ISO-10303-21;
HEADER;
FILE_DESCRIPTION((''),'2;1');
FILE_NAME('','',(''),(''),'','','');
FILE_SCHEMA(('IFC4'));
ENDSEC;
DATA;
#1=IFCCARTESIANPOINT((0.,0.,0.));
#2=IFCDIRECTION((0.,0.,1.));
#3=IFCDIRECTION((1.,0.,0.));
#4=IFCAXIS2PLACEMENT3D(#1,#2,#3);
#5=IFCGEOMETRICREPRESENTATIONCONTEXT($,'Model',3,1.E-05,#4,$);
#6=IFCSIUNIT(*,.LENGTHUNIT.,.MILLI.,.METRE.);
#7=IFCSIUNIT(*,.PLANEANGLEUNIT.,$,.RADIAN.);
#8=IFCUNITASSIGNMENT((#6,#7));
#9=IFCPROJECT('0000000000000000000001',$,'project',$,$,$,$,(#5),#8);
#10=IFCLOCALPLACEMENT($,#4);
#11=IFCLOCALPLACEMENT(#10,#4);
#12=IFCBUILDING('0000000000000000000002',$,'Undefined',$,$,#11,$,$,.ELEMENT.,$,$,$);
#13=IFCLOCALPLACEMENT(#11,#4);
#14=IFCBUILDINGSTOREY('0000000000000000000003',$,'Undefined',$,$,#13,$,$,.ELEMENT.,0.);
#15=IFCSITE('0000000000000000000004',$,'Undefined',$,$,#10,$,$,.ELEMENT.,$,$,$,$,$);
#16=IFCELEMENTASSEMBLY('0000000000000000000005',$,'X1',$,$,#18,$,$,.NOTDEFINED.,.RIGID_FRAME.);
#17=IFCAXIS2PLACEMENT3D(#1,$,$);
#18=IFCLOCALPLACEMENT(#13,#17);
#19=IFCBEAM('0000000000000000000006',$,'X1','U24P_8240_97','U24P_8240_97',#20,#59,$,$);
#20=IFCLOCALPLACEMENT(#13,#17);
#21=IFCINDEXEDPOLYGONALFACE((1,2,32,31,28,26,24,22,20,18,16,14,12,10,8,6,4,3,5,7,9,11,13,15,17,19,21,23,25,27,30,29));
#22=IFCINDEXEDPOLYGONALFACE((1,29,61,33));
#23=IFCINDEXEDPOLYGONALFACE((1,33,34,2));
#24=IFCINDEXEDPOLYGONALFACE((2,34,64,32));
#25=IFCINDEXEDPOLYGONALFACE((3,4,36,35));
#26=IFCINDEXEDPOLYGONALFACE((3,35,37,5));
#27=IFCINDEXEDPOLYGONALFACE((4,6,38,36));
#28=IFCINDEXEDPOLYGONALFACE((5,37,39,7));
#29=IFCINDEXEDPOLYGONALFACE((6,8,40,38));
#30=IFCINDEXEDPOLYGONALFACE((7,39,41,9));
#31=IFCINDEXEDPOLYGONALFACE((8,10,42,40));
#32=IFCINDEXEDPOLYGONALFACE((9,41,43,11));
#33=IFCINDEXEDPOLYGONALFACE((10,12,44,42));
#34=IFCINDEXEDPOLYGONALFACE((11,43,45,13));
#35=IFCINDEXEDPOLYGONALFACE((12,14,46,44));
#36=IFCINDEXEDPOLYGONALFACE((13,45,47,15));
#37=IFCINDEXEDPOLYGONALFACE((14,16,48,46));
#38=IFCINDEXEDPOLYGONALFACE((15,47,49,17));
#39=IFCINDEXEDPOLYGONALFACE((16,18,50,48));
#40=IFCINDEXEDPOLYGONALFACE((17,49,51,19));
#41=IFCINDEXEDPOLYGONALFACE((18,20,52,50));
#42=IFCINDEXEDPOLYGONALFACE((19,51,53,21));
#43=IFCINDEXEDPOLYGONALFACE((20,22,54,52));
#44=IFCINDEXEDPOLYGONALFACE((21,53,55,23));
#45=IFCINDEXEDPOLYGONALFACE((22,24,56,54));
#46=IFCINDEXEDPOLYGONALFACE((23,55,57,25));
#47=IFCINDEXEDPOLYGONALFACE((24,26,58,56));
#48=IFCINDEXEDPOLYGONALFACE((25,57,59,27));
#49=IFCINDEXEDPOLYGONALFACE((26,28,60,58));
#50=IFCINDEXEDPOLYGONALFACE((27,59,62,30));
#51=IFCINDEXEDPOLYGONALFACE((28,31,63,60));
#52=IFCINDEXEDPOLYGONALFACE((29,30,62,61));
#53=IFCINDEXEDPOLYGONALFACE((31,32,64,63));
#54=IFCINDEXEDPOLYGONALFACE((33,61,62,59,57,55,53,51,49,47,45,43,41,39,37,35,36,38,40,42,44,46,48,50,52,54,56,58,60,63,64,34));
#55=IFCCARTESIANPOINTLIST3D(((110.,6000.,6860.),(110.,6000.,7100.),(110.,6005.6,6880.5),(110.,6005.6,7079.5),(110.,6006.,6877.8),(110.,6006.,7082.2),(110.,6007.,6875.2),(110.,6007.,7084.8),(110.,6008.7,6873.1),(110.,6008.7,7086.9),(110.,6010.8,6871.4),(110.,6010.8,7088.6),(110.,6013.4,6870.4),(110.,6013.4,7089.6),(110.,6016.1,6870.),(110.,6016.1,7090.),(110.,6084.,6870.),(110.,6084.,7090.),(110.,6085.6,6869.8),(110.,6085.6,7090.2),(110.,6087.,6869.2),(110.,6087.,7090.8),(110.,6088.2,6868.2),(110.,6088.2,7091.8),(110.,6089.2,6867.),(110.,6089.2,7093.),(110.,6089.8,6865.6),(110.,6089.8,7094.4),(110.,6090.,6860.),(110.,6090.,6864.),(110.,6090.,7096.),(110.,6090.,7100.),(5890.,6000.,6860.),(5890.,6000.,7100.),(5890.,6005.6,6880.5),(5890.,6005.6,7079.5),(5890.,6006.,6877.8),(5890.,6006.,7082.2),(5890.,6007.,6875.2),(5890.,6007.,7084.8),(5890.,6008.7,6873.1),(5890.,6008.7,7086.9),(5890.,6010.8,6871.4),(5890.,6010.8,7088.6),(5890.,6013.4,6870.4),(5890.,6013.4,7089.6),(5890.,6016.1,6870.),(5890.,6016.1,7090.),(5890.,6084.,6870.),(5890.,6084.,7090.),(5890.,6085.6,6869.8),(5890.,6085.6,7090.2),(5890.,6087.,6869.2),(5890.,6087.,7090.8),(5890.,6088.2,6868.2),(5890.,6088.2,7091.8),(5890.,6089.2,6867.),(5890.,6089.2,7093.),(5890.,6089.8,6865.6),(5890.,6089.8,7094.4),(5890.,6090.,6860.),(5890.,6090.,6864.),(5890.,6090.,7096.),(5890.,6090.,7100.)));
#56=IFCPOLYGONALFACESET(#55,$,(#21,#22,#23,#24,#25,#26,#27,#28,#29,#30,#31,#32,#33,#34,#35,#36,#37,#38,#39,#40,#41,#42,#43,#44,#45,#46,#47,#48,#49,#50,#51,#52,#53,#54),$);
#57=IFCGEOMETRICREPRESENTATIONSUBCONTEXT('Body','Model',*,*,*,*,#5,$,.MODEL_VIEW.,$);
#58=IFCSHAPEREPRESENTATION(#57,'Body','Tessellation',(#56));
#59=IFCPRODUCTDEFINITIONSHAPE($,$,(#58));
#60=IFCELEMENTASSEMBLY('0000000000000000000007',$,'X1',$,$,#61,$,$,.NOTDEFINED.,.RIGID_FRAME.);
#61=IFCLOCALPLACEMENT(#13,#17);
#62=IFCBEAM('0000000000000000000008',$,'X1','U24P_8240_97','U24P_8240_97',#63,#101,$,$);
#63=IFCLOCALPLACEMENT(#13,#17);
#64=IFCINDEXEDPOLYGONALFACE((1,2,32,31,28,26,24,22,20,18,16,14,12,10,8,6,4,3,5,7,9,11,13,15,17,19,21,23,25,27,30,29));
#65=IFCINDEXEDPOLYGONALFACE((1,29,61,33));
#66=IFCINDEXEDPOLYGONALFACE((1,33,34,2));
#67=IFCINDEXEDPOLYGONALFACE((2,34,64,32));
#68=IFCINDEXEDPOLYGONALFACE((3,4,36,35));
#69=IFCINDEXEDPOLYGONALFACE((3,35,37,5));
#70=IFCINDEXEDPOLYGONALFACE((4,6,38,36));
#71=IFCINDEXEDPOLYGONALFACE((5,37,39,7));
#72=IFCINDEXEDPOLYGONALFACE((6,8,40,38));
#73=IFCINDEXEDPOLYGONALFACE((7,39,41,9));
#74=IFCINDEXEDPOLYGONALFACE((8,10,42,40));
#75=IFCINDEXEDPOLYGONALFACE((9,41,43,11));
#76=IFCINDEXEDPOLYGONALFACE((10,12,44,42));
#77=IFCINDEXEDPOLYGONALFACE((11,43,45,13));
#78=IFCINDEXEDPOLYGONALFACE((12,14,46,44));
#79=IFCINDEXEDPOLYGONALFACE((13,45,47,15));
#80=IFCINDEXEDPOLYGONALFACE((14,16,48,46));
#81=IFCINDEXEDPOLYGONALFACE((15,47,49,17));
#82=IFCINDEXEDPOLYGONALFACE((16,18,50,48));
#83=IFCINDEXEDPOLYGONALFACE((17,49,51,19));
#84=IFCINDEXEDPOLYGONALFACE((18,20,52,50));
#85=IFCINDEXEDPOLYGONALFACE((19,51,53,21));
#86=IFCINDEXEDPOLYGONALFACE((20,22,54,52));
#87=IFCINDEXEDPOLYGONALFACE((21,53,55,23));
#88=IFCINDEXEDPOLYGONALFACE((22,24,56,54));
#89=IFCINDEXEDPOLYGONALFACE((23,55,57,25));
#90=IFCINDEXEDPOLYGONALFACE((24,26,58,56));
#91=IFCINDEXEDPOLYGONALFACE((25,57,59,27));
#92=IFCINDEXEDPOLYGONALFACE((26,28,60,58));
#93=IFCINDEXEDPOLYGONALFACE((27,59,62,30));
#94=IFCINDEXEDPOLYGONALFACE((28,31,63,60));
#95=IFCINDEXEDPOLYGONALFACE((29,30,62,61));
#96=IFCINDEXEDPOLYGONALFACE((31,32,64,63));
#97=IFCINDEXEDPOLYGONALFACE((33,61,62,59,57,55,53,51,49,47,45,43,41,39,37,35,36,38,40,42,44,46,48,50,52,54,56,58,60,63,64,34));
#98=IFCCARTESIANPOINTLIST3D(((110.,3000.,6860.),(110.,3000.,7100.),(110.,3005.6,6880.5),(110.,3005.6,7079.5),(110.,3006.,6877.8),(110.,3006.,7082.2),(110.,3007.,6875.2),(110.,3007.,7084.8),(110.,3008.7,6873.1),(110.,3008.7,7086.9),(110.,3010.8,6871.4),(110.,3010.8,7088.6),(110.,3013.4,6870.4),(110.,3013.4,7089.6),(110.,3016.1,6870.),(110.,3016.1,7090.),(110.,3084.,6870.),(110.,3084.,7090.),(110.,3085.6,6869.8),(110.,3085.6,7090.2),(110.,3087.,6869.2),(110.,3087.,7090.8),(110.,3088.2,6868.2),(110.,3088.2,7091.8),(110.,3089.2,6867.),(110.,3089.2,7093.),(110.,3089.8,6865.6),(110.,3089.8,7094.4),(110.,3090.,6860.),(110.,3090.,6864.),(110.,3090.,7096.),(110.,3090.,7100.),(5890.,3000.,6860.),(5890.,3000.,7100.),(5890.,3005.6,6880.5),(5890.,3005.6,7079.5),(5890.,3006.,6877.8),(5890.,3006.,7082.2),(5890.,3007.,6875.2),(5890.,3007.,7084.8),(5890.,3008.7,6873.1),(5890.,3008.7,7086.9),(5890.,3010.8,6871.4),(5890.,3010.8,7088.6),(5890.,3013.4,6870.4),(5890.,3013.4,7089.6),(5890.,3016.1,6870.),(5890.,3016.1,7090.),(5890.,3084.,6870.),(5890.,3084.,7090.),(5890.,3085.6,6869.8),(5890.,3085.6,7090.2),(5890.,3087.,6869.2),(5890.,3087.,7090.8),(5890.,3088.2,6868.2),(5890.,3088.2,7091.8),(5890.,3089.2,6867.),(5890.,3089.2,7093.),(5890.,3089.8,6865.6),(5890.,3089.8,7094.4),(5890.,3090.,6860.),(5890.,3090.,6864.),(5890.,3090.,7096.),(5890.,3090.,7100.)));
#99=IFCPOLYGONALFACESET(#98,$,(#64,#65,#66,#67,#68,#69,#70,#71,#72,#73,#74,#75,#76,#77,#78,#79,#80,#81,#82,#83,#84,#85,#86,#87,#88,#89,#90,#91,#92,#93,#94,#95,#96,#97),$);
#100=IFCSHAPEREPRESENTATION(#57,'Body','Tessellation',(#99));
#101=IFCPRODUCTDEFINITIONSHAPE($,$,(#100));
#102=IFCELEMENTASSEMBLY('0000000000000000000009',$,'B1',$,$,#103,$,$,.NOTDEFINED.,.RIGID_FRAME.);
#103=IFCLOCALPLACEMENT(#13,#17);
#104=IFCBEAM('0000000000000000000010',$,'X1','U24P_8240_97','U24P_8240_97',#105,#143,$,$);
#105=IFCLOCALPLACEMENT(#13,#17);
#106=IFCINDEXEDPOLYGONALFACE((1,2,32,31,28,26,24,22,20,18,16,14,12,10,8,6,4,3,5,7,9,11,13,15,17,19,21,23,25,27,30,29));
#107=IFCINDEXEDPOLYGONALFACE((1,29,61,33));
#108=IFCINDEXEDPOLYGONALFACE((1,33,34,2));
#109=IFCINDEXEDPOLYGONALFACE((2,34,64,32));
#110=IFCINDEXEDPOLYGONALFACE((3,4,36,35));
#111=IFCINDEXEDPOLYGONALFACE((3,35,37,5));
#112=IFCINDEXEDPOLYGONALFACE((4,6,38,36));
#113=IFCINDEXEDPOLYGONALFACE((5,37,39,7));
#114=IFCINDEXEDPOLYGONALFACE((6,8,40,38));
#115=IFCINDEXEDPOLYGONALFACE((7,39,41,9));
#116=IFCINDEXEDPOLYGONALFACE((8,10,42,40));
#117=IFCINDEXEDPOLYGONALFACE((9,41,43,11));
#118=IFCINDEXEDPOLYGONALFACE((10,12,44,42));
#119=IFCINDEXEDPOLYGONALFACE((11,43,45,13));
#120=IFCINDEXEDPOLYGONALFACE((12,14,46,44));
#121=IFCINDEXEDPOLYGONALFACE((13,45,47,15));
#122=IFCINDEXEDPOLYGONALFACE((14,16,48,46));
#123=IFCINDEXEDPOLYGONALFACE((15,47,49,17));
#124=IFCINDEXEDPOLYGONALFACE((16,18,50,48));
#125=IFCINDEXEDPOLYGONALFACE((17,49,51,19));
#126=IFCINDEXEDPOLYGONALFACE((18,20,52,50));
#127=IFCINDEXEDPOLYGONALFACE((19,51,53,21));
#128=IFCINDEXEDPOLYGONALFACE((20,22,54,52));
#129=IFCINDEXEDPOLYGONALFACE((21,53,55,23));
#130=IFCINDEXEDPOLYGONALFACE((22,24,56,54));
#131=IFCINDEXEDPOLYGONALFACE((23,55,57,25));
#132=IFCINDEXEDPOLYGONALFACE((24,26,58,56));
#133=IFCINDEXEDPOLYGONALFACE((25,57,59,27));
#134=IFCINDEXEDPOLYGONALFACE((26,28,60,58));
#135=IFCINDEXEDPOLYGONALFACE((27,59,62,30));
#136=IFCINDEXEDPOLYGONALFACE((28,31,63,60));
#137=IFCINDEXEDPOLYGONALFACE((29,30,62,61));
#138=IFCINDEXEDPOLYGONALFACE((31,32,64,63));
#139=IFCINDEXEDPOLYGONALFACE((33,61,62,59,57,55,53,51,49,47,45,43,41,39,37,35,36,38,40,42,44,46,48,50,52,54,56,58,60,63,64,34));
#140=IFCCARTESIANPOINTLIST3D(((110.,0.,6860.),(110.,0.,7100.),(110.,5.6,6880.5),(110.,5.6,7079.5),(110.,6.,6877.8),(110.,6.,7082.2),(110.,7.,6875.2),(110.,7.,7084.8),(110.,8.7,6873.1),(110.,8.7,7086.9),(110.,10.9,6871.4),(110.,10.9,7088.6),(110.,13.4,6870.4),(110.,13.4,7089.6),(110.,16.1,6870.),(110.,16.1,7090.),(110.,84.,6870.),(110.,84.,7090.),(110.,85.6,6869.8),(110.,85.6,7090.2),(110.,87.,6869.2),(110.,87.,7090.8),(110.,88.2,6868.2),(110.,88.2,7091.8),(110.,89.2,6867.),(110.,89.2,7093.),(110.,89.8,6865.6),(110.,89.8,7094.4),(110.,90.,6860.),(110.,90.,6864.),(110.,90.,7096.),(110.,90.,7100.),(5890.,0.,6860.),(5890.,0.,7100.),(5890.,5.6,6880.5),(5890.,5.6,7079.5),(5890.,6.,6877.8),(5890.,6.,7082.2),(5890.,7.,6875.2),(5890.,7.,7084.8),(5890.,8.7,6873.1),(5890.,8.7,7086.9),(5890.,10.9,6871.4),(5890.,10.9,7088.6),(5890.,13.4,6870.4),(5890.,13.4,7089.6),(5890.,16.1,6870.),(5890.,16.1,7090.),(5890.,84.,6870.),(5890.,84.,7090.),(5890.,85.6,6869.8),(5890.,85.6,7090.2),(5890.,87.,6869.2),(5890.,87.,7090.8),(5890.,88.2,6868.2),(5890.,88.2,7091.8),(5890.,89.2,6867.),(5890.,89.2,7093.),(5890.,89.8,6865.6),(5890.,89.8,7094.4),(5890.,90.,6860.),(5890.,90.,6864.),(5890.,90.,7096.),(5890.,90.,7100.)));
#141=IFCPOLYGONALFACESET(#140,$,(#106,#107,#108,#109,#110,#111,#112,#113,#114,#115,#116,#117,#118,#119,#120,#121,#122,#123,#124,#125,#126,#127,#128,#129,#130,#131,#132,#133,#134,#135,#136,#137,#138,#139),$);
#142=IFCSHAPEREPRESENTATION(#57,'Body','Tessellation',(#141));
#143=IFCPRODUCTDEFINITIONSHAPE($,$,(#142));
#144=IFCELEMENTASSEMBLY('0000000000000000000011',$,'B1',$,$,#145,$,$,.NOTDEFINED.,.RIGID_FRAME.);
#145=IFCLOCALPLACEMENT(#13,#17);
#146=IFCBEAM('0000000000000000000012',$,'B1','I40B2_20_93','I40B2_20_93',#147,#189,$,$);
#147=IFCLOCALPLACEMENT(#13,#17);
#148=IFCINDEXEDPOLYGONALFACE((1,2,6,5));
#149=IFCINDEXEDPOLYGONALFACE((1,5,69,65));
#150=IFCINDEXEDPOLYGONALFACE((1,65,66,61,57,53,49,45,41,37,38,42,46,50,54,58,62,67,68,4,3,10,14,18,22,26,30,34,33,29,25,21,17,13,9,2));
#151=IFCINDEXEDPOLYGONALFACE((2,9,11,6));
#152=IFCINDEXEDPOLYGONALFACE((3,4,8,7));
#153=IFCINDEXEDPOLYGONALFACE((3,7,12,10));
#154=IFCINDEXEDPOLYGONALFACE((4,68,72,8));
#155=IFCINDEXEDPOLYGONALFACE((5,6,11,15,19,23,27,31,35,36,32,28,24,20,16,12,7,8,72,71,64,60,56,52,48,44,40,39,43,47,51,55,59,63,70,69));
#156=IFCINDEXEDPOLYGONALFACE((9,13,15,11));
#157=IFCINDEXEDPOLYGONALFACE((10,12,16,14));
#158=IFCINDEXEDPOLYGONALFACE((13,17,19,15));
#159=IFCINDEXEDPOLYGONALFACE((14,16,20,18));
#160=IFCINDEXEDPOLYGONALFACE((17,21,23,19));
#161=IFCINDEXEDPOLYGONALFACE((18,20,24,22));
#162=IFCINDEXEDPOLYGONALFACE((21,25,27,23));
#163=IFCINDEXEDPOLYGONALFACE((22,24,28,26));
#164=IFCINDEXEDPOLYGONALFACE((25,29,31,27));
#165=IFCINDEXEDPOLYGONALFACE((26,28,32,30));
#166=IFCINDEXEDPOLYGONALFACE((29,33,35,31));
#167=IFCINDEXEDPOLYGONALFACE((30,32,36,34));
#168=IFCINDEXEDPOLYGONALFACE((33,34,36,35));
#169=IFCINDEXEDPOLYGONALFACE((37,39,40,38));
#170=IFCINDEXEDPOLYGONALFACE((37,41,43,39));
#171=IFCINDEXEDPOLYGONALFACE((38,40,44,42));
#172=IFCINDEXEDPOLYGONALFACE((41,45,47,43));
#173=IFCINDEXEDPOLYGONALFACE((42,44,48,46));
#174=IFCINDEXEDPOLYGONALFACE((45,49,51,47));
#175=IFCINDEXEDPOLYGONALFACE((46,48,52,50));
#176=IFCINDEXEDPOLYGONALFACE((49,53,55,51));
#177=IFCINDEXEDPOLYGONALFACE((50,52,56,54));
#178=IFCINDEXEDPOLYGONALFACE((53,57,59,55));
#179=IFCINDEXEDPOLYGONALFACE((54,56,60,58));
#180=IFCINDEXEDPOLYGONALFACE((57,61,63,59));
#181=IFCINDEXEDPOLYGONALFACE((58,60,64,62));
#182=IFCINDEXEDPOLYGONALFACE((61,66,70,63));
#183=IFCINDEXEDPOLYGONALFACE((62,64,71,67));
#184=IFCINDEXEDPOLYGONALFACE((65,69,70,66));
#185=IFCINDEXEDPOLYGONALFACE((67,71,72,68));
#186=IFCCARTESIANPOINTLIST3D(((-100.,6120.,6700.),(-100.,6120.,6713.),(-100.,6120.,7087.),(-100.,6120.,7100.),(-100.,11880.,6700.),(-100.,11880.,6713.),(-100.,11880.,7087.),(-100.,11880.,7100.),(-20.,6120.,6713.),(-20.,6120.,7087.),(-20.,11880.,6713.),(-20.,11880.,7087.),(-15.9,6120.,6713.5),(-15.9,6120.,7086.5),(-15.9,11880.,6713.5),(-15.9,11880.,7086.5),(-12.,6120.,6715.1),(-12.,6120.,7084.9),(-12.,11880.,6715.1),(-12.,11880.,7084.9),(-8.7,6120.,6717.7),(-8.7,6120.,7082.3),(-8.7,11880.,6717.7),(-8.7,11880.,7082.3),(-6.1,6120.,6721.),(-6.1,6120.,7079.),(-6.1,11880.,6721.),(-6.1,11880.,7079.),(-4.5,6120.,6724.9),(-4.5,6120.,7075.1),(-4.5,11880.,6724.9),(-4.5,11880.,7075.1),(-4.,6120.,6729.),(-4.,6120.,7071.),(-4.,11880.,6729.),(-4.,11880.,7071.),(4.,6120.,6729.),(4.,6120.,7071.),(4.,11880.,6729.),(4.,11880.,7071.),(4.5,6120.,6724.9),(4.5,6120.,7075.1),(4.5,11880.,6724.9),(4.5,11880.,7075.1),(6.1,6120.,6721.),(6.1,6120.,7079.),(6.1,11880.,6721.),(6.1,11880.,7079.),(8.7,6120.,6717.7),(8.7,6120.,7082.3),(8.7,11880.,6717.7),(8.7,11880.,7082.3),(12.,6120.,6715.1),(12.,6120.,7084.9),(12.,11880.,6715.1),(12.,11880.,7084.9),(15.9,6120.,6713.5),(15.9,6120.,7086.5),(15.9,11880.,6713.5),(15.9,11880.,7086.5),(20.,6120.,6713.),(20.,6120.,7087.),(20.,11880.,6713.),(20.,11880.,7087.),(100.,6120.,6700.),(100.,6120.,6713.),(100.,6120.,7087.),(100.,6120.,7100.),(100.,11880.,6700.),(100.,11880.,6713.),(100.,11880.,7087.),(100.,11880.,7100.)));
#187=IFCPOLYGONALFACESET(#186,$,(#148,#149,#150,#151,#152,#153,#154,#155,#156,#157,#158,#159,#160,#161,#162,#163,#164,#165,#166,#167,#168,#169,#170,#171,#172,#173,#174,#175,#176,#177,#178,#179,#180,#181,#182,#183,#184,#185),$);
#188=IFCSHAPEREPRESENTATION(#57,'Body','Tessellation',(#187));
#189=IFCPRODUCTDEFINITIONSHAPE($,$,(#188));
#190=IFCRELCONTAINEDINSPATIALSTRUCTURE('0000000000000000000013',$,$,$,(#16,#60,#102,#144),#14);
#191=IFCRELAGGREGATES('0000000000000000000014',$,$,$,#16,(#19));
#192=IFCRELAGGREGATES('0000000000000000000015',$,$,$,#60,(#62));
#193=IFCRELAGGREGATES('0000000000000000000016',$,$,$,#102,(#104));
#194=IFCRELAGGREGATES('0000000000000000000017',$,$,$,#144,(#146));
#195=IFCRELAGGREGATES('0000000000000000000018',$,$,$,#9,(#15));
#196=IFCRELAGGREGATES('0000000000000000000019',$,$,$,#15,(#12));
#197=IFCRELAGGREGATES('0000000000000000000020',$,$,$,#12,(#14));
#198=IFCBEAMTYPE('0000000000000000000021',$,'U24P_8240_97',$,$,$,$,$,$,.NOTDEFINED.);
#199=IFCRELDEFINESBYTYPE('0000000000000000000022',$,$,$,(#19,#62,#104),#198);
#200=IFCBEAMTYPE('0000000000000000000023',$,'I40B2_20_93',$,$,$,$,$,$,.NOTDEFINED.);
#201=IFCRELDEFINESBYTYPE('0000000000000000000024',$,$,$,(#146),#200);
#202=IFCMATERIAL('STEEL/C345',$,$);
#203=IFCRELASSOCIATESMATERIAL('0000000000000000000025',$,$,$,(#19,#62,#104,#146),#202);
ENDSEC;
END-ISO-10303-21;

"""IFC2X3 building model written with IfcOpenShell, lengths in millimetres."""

from ifc_helpers import new_model, si_unit, frame, origin_with_axes, origin_2d_with_axis, place, context, subcontext, project, spatial, i_section, u_section, extrude, material, type_object, element, aggregate, save


model = new_model("IFC2X3")

# Units and contexts
model_context = context("Model", 3, precision=1e-05, world=origin_with_axes())
body_context = subcontext(model_context, "Body", "Model", "MODEL_VIEW")
ifc_project = project(units=[si_unit("LENGTHUNIT", "METRE", prefix="MILLI"), si_unit("PLANEANGLEUNIT", "RADIAN")], contexts=[model_context])

# Site, building, storey
site_placement = place(None, origin_with_axes())
site = spatial("IfcSite", under=ifc_project, at=site_placement, Name="Undefined", CompositionType="ELEMENT")
building_placement = place(site_placement, origin_with_axes())
building = spatial("IfcBuilding", under=site, at=building_placement, Name="Undefined", CompositionType="ELEMENT")
storey_placement = place(building_placement, origin_with_axes())
storey = spatial("IfcBuildingStorey", under=building, at=storey_placement, Name="Undefined", CompositionType="ELEMENT", Elevation=0.0)

# Element assemblies, beams
assembly_1_placement = place(storey_placement, origin_with_axes())
assembly_1 = element("IfcElementAssembly", 1, at=assembly_1_placement, inside=storey, Name="X1", AssemblyPlace="NOTDEFINED", PredefinedType="RIGID_FRAME")
ifc_material_1 = material(Name="STEEL/C345")
beam_type_1 = type_object("IfcBeamType", Name="U24P_8240_97", PredefinedType="NOTDEFINED")
beam_1_placement = place(assembly_1_placement, frame((110.0, 6045.0, 6980.0), z_axis=(0.0, 0.0, -1.0), x_axis=(1.0, 0.0, 0.0)))
beam_1 = element("IfcBeam", 2, at=beam_1_placement, type_object=beam_type_1, material=ifc_material_1, Name="X1", Description="U24P_8240_97", ObjectType="U24P_8240_97", context=body_context, shape_type="SweptSolid", body=[
    extrude(u_section(Depth=240.0, FlangeWidth=90.0, WebThickness=5.6, FlangeThickness=10.0, FilletRadius=10.5, EdgeRadius=6.0, at=origin_2d_with_axis()), frame((5780.0, 0.0, 0.0), z_axis=(-1.0, 0.0, 0.0), x_axis=(0.0, -1.0, 0.0)), (0.0, 0.0, 1.0), 5780.0),
])
aggregate(assembly_1, [beam_1])
assembly_2_placement = place(storey_placement, origin_with_axes())
assembly_2 = element("IfcElementAssembly", 3, at=assembly_2_placement, inside=storey, Name="X1", AssemblyPlace="NOTDEFINED", PredefinedType="RIGID_FRAME")
beam_2_placement = place(assembly_2_placement, frame((110.0, 3045.0, 6980.0), z_axis=(0.0, 0.0, -1.0), x_axis=(1.0, 0.0, 0.0)))
beam_2 = element("IfcBeam", 4, at=beam_2_placement, type_object=beam_type_1, material=ifc_material_1, Name="X1", Description="U24P_8240_97", ObjectType="U24P_8240_97", context=body_context, shape_type="SweptSolid", body=[
    extrude(u_section(Depth=240.0, FlangeWidth=90.0, WebThickness=5.6, FlangeThickness=10.0, FilletRadius=10.5, EdgeRadius=6.0, at=origin_2d_with_axis()), frame((5780.0, 0.0, 0.0), z_axis=(-1.0, 0.0, 0.0), x_axis=(0.0, -1.0, 0.0)), (0.0, 0.0, 1.0), 5780.0),
])
aggregate(assembly_2, [beam_2])
assembly_3_placement = place(storey_placement, origin_with_axes())
assembly_3 = element("IfcElementAssembly", 5, at=assembly_3_placement, inside=storey, Name="B1", AssemblyPlace="NOTDEFINED", PredefinedType="RIGID_FRAME")
beam_3_placement = place(assembly_3_placement, frame((110.0, 45.0, 6980.0), z_axis=(0.0, 0.0, -1.0), x_axis=(1.0, 0.0, 0.0)))
beam_3 = element("IfcBeam", 6, at=beam_3_placement, type_object=beam_type_1, material=ifc_material_1, Name="X1", Description="U24P_8240_97", ObjectType="U24P_8240_97", context=body_context, shape_type="SweptSolid", body=[
    extrude(u_section(Depth=240.0, FlangeWidth=90.0, WebThickness=5.6, FlangeThickness=10.0, FilletRadius=10.5, EdgeRadius=6.0, at=origin_2d_with_axis()), frame((5780.0, 0.0, 0.0), z_axis=(-1.0, 0.0, 0.0), x_axis=(0.0, -1.0, 0.0)), (0.0, 0.0, 1.0), 5780.0),
])
aggregate(assembly_3, [beam_3])
assembly_4_placement = place(storey_placement, origin_with_axes())
assembly_4 = element("IfcElementAssembly", 7, at=assembly_4_placement, inside=storey, Name="B1", AssemblyPlace="NOTDEFINED", PredefinedType="RIGID_FRAME")
beam_type_2 = type_object("IfcBeamType", Name="I40B2_20_93", PredefinedType="NOTDEFINED")
beam_4_placement = place(assembly_4_placement, frame((0.0, 6120.0, 6900.0), z_axis=(0.0, 0.0, 1.0), x_axis=(0.0, 1.0, 0.0)))
beam_4 = element("IfcBeam", 8, at=beam_4_placement, type_object=beam_type_2, material=ifc_material_1, Name="B1", Description="I40B2_20_93", ObjectType="I40B2_20_93", context=body_context, shape_type="SweptSolid", body=[
    extrude(i_section(OverallWidth=200.0, OverallDepth=400.0, WebThickness=8.0, FlangeThickness=13.0, FilletRadius=16.0, at=origin_2d_with_axis()), frame((5760.0, 0.0, 0.0), z_axis=(-1.0, 0.0, 0.0), x_axis=(0.0, -1.0, 0.0)), (0.0, 0.0, 1.0), 5760.0),
])
aggregate(assembly_4, [beam_4])

save(model, "model.ifc")
